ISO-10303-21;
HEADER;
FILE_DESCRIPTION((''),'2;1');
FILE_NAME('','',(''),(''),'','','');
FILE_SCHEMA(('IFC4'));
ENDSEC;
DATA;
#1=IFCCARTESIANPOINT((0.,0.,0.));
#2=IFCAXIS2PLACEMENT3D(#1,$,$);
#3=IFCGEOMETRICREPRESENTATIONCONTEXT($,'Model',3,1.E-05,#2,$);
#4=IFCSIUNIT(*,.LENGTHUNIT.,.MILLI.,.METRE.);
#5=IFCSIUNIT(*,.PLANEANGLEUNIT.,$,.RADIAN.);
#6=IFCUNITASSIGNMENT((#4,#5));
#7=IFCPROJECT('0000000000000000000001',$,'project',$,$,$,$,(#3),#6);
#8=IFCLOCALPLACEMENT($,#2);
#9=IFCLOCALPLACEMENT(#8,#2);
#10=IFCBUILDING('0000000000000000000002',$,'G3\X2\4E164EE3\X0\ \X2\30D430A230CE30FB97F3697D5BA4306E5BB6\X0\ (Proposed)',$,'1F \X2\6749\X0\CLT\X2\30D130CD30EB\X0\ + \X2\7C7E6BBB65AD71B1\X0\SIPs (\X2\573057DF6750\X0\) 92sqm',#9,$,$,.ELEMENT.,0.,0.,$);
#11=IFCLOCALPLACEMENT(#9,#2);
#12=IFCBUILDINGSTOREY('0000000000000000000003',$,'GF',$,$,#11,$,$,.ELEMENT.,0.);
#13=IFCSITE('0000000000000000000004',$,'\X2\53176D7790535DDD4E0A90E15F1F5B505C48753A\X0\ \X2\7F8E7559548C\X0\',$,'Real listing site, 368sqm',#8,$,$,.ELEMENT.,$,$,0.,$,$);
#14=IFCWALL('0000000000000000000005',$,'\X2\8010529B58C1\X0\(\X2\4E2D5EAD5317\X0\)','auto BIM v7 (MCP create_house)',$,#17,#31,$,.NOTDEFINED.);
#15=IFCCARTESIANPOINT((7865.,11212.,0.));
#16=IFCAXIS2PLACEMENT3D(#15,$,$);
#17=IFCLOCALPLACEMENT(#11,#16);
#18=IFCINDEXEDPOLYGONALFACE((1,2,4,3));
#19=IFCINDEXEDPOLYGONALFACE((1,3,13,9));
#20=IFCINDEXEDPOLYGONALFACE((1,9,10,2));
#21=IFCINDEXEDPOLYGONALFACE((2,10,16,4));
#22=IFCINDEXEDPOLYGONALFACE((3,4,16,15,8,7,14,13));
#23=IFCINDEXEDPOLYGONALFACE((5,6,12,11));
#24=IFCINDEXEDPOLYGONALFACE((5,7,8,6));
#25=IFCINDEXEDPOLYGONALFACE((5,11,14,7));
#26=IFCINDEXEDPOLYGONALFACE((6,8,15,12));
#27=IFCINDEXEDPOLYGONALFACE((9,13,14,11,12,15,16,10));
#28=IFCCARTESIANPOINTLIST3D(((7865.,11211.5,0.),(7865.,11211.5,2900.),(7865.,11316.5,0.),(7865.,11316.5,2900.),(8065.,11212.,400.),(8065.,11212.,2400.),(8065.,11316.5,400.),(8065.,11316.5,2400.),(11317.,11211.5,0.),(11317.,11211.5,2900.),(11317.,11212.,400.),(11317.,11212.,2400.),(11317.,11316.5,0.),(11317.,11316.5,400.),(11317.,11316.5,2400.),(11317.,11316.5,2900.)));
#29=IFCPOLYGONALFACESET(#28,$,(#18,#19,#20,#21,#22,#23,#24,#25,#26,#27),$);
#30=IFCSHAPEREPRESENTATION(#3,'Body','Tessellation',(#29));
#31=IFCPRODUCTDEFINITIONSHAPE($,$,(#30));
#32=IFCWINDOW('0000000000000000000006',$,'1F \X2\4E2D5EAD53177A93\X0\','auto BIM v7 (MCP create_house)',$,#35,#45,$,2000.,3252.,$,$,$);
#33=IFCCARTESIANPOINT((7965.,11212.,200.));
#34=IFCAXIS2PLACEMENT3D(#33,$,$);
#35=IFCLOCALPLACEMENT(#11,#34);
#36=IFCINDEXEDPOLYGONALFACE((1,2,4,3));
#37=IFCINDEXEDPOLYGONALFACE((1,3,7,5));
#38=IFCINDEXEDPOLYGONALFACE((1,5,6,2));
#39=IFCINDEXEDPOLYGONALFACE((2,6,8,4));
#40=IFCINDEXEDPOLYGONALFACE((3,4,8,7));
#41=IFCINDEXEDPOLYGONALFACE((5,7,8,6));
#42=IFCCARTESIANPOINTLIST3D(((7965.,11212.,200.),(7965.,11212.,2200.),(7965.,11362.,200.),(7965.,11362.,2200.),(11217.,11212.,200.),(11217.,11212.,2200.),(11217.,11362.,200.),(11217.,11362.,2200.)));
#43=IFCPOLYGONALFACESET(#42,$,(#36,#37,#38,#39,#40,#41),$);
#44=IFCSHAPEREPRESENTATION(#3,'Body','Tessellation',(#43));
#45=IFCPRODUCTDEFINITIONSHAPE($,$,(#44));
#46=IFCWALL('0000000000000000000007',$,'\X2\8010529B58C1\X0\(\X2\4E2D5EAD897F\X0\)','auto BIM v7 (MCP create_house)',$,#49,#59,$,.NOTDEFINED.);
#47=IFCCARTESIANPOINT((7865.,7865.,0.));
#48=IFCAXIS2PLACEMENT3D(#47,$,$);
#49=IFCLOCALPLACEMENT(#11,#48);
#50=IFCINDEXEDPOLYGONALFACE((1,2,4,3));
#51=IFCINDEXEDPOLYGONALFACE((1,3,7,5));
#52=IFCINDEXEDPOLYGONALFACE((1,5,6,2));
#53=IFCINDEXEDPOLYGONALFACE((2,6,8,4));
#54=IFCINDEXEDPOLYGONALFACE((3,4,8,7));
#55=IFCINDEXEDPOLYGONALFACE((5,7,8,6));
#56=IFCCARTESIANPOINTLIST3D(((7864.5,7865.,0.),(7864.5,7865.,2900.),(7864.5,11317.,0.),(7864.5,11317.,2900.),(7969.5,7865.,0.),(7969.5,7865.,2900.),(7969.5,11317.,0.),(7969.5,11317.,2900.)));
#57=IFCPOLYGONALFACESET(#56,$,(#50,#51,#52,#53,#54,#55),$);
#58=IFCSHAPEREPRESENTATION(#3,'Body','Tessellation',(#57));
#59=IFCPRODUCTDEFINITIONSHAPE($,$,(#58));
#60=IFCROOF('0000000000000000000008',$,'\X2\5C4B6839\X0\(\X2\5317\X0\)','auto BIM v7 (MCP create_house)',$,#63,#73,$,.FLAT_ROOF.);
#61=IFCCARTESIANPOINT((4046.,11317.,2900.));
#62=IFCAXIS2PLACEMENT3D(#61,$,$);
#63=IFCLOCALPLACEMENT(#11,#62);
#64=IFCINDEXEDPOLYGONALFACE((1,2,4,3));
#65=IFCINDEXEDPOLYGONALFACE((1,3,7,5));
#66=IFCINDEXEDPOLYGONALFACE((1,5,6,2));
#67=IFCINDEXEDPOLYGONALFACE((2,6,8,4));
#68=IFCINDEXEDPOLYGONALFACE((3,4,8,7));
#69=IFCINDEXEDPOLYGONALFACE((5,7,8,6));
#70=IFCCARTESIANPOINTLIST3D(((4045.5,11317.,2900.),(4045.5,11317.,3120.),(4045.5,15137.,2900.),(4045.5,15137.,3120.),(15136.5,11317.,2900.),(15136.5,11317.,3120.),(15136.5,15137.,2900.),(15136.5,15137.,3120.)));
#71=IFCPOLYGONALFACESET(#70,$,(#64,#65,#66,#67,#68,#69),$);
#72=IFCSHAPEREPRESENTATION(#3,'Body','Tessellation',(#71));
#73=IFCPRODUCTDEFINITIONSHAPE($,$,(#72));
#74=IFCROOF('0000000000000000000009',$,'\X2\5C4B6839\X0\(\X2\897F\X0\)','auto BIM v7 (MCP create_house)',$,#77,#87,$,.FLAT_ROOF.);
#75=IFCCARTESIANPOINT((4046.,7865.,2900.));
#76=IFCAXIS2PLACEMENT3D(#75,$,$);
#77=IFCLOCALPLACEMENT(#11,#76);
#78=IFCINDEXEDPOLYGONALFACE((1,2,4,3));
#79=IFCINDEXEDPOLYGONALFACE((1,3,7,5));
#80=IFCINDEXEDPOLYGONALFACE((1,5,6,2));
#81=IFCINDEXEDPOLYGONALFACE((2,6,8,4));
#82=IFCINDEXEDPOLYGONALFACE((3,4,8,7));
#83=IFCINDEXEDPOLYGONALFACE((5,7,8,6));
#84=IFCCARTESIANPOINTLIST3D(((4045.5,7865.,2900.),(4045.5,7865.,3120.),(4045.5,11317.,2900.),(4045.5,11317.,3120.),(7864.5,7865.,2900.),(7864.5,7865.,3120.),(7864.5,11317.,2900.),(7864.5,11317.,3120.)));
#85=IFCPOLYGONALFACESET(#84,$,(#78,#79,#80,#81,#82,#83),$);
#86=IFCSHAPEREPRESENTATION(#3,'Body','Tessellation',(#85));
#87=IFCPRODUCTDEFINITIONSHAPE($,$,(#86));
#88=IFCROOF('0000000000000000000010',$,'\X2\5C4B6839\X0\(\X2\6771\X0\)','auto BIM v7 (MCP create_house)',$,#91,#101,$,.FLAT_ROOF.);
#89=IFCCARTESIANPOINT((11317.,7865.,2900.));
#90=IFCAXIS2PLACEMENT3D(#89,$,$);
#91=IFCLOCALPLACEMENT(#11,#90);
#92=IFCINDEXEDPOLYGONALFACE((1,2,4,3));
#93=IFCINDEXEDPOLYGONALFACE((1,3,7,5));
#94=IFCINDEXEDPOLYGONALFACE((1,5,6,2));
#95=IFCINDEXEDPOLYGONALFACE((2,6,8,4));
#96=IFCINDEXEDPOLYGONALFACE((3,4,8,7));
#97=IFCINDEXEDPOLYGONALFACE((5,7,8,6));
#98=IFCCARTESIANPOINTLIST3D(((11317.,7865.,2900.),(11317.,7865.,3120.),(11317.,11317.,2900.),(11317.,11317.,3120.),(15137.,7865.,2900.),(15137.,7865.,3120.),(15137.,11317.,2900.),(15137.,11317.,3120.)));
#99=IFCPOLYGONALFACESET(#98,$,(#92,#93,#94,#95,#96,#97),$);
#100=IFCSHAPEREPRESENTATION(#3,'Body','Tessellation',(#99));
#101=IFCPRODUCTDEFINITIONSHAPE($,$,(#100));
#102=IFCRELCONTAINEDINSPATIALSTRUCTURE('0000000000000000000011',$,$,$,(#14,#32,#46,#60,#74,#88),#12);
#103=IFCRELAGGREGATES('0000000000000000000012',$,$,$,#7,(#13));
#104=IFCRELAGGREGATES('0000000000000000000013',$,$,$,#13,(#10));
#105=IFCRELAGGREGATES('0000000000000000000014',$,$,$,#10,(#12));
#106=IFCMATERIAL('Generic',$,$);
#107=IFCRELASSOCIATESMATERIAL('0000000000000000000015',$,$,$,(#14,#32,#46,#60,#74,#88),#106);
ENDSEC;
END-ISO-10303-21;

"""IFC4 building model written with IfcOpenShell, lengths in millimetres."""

from ifc_helpers import new_model, si_unit, frame, frame_2d, origin, place, context, project, spatial, rectangle, extrude, material, element, fill, save


model = new_model("IFC4")

# Units and contexts
model_context = context("Model", 3, precision=1e-05, world=origin())
ifc_project = project(units=[si_unit("LENGTHUNIT", "METRE", prefix="MILLI"), si_unit("PLANEANGLEUNIT", "RADIAN")], contexts=[model_context])

# Site, building, storey
site_placement = place(None, origin())
site = spatial("IfcSite", under=ifc_project, at=site_placement, Name="北海道川上郡弟子屈町 美留和", ObjectType="Real listing site, 368sqm", CompositionType="ELEMENT", RefElevation=0.0)
building_placement = place(site_placement, origin())
building = spatial("IfcBuilding", under=site, at=building_placement, Name="G3世代 ピアノ・音楽室の家 (Proposed)", ObjectType="1F 杉CLTパネル + 籾殻断熱SIPs (地域材) 92sqm", CompositionType="ELEMENT", ElevationOfRefHeight=0.0, ElevationOfTerrain=0.0)
storey_placement = place(building_placement, origin())
storey = spatial("IfcBuildingStorey", under=building, at=storey_placement, Name="GF", CompositionType="ELEMENT", Elevation=0.0)

# Shared definitions
ifc_material = material(Name="Generic")

# Wall, opening, window
wall_1_placement = place(storey_placement, frame((7865.0, 11212.0, 0.0)))
wall_1 = element("IfcWall", 1, at=wall_1_placement, inside=storey, material=ifc_material, Name="耐力壁(中庭北)", Description="auto BIM v7 (MCP create_house)", PredefinedType="NOTDEFINED", context=model_context, shape_type="SweptSolid", body=[
    extrude(rectangle(XDim=3452.0, YDim=105.0, at=frame_2d((1726.0, 52.0))), frame((7865.0, 11212.0, 0.0)), (0.0, 0.0, 1.0), 2900.0),
])
opening_1_placement = place(storey_placement, frame((7965.0, 11212.0, 200.0)))
opening_1 = element("IfcOpeningElement", 2, at=opening_1_placement, cuts=wall_1, PredefinedType="NOTDEFINED", context=model_context, shape_type="SweptSolid", body=[
    extrude(rectangle(XDim=3252.0, YDim=150.0, at=frame_2d((1626.0, 75.0))), frame((7965.0, 11212.0, 200.0)), (0.0, 0.0, 1.0), 2000.0),
])
window_1_placement = place(storey_placement, frame((7965.0, 11212.0, 200.0)))
window_1 = element("IfcWindow", 3, at=window_1_placement, inside=storey, material=ifc_material, Name="1F 中庭北窓", Description="auto BIM v7 (MCP create_house)", OverallHeight=2000.0, OverallWidth=3252.0, context=model_context, shape_type="SweptSolid", body=[
    extrude(rectangle(XDim=3252.0, YDim=150.0, at=frame_2d((1626.0, 75.0))), frame((7965.0, 11212.0, 200.0)), (0.0, 0.0, 1.0), 2000.0),
])
fill(opening_1, window_1)

# Wall
wall_2_placement = place(storey_placement, frame((7865.0, 7865.0, 0.0)))
element("IfcWall", 4, at=wall_2_placement, inside=storey, material=ifc_material, Name="耐力壁(中庭西)", Description="auto BIM v7 (MCP create_house)", PredefinedType="NOTDEFINED", context=model_context, shape_type="SweptSolid", body=[
    extrude(rectangle(XDim=105.0, YDim=3452.0, at=frame_2d((52.0, 1726.0))), frame((7865.0, 7865.0, 0.0)), (0.0, 0.0, 1.0), 2900.0),
])

# Roofs
roof_1_placement = place(storey_placement, frame((4046.0, 11317.0, 2900.0)))
element("IfcRoof", 5, at=roof_1_placement, inside=storey, material=ifc_material, Name="屋根(北)", Description="auto BIM v7 (MCP create_house)", PredefinedType="FLAT_ROOF", context=model_context, shape_type="SweptSolid", body=[
    extrude(rectangle(XDim=11091.0, YDim=3820.0, at=frame_2d((5545.0, 1910.0))), frame((4046.0, 11317.0, 2900.0)), (0.0, 0.0, 1.0), 220.0),
])
roof_2_placement = place(storey_placement, frame((4046.0, 7865.0, 2900.0)))
element("IfcRoof", 6, at=roof_2_placement, inside=storey, material=ifc_material, Name="屋根(西)", Description="auto BIM v7 (MCP create_house)", PredefinedType="FLAT_ROOF", context=model_context, shape_type="SweptSolid", body=[
    extrude(rectangle(XDim=3819.0, YDim=3452.0, at=frame_2d((1909.0, 1726.0))), frame((4046.0, 7865.0, 2900.0)), (0.0, 0.0, 1.0), 220.0),
])
roof_3_placement = place(storey_placement, frame((11317.0, 7865.0, 2900.0)))
element("IfcRoof", 7, at=roof_3_placement, inside=storey, material=ifc_material, Name="屋根(東)", Description="auto BIM v7 (MCP create_house)", PredefinedType="FLAT_ROOF", context=model_context, shape_type="SweptSolid", body=[
    extrude(rectangle(XDim=3820.0, YDim=3452.0, at=frame_2d((1910.0, 1726.0))), frame((11317.0, 7865.0, 2900.0)), (0.0, 0.0, 1.0), 220.0),
])

save(model, "model.ifc")
